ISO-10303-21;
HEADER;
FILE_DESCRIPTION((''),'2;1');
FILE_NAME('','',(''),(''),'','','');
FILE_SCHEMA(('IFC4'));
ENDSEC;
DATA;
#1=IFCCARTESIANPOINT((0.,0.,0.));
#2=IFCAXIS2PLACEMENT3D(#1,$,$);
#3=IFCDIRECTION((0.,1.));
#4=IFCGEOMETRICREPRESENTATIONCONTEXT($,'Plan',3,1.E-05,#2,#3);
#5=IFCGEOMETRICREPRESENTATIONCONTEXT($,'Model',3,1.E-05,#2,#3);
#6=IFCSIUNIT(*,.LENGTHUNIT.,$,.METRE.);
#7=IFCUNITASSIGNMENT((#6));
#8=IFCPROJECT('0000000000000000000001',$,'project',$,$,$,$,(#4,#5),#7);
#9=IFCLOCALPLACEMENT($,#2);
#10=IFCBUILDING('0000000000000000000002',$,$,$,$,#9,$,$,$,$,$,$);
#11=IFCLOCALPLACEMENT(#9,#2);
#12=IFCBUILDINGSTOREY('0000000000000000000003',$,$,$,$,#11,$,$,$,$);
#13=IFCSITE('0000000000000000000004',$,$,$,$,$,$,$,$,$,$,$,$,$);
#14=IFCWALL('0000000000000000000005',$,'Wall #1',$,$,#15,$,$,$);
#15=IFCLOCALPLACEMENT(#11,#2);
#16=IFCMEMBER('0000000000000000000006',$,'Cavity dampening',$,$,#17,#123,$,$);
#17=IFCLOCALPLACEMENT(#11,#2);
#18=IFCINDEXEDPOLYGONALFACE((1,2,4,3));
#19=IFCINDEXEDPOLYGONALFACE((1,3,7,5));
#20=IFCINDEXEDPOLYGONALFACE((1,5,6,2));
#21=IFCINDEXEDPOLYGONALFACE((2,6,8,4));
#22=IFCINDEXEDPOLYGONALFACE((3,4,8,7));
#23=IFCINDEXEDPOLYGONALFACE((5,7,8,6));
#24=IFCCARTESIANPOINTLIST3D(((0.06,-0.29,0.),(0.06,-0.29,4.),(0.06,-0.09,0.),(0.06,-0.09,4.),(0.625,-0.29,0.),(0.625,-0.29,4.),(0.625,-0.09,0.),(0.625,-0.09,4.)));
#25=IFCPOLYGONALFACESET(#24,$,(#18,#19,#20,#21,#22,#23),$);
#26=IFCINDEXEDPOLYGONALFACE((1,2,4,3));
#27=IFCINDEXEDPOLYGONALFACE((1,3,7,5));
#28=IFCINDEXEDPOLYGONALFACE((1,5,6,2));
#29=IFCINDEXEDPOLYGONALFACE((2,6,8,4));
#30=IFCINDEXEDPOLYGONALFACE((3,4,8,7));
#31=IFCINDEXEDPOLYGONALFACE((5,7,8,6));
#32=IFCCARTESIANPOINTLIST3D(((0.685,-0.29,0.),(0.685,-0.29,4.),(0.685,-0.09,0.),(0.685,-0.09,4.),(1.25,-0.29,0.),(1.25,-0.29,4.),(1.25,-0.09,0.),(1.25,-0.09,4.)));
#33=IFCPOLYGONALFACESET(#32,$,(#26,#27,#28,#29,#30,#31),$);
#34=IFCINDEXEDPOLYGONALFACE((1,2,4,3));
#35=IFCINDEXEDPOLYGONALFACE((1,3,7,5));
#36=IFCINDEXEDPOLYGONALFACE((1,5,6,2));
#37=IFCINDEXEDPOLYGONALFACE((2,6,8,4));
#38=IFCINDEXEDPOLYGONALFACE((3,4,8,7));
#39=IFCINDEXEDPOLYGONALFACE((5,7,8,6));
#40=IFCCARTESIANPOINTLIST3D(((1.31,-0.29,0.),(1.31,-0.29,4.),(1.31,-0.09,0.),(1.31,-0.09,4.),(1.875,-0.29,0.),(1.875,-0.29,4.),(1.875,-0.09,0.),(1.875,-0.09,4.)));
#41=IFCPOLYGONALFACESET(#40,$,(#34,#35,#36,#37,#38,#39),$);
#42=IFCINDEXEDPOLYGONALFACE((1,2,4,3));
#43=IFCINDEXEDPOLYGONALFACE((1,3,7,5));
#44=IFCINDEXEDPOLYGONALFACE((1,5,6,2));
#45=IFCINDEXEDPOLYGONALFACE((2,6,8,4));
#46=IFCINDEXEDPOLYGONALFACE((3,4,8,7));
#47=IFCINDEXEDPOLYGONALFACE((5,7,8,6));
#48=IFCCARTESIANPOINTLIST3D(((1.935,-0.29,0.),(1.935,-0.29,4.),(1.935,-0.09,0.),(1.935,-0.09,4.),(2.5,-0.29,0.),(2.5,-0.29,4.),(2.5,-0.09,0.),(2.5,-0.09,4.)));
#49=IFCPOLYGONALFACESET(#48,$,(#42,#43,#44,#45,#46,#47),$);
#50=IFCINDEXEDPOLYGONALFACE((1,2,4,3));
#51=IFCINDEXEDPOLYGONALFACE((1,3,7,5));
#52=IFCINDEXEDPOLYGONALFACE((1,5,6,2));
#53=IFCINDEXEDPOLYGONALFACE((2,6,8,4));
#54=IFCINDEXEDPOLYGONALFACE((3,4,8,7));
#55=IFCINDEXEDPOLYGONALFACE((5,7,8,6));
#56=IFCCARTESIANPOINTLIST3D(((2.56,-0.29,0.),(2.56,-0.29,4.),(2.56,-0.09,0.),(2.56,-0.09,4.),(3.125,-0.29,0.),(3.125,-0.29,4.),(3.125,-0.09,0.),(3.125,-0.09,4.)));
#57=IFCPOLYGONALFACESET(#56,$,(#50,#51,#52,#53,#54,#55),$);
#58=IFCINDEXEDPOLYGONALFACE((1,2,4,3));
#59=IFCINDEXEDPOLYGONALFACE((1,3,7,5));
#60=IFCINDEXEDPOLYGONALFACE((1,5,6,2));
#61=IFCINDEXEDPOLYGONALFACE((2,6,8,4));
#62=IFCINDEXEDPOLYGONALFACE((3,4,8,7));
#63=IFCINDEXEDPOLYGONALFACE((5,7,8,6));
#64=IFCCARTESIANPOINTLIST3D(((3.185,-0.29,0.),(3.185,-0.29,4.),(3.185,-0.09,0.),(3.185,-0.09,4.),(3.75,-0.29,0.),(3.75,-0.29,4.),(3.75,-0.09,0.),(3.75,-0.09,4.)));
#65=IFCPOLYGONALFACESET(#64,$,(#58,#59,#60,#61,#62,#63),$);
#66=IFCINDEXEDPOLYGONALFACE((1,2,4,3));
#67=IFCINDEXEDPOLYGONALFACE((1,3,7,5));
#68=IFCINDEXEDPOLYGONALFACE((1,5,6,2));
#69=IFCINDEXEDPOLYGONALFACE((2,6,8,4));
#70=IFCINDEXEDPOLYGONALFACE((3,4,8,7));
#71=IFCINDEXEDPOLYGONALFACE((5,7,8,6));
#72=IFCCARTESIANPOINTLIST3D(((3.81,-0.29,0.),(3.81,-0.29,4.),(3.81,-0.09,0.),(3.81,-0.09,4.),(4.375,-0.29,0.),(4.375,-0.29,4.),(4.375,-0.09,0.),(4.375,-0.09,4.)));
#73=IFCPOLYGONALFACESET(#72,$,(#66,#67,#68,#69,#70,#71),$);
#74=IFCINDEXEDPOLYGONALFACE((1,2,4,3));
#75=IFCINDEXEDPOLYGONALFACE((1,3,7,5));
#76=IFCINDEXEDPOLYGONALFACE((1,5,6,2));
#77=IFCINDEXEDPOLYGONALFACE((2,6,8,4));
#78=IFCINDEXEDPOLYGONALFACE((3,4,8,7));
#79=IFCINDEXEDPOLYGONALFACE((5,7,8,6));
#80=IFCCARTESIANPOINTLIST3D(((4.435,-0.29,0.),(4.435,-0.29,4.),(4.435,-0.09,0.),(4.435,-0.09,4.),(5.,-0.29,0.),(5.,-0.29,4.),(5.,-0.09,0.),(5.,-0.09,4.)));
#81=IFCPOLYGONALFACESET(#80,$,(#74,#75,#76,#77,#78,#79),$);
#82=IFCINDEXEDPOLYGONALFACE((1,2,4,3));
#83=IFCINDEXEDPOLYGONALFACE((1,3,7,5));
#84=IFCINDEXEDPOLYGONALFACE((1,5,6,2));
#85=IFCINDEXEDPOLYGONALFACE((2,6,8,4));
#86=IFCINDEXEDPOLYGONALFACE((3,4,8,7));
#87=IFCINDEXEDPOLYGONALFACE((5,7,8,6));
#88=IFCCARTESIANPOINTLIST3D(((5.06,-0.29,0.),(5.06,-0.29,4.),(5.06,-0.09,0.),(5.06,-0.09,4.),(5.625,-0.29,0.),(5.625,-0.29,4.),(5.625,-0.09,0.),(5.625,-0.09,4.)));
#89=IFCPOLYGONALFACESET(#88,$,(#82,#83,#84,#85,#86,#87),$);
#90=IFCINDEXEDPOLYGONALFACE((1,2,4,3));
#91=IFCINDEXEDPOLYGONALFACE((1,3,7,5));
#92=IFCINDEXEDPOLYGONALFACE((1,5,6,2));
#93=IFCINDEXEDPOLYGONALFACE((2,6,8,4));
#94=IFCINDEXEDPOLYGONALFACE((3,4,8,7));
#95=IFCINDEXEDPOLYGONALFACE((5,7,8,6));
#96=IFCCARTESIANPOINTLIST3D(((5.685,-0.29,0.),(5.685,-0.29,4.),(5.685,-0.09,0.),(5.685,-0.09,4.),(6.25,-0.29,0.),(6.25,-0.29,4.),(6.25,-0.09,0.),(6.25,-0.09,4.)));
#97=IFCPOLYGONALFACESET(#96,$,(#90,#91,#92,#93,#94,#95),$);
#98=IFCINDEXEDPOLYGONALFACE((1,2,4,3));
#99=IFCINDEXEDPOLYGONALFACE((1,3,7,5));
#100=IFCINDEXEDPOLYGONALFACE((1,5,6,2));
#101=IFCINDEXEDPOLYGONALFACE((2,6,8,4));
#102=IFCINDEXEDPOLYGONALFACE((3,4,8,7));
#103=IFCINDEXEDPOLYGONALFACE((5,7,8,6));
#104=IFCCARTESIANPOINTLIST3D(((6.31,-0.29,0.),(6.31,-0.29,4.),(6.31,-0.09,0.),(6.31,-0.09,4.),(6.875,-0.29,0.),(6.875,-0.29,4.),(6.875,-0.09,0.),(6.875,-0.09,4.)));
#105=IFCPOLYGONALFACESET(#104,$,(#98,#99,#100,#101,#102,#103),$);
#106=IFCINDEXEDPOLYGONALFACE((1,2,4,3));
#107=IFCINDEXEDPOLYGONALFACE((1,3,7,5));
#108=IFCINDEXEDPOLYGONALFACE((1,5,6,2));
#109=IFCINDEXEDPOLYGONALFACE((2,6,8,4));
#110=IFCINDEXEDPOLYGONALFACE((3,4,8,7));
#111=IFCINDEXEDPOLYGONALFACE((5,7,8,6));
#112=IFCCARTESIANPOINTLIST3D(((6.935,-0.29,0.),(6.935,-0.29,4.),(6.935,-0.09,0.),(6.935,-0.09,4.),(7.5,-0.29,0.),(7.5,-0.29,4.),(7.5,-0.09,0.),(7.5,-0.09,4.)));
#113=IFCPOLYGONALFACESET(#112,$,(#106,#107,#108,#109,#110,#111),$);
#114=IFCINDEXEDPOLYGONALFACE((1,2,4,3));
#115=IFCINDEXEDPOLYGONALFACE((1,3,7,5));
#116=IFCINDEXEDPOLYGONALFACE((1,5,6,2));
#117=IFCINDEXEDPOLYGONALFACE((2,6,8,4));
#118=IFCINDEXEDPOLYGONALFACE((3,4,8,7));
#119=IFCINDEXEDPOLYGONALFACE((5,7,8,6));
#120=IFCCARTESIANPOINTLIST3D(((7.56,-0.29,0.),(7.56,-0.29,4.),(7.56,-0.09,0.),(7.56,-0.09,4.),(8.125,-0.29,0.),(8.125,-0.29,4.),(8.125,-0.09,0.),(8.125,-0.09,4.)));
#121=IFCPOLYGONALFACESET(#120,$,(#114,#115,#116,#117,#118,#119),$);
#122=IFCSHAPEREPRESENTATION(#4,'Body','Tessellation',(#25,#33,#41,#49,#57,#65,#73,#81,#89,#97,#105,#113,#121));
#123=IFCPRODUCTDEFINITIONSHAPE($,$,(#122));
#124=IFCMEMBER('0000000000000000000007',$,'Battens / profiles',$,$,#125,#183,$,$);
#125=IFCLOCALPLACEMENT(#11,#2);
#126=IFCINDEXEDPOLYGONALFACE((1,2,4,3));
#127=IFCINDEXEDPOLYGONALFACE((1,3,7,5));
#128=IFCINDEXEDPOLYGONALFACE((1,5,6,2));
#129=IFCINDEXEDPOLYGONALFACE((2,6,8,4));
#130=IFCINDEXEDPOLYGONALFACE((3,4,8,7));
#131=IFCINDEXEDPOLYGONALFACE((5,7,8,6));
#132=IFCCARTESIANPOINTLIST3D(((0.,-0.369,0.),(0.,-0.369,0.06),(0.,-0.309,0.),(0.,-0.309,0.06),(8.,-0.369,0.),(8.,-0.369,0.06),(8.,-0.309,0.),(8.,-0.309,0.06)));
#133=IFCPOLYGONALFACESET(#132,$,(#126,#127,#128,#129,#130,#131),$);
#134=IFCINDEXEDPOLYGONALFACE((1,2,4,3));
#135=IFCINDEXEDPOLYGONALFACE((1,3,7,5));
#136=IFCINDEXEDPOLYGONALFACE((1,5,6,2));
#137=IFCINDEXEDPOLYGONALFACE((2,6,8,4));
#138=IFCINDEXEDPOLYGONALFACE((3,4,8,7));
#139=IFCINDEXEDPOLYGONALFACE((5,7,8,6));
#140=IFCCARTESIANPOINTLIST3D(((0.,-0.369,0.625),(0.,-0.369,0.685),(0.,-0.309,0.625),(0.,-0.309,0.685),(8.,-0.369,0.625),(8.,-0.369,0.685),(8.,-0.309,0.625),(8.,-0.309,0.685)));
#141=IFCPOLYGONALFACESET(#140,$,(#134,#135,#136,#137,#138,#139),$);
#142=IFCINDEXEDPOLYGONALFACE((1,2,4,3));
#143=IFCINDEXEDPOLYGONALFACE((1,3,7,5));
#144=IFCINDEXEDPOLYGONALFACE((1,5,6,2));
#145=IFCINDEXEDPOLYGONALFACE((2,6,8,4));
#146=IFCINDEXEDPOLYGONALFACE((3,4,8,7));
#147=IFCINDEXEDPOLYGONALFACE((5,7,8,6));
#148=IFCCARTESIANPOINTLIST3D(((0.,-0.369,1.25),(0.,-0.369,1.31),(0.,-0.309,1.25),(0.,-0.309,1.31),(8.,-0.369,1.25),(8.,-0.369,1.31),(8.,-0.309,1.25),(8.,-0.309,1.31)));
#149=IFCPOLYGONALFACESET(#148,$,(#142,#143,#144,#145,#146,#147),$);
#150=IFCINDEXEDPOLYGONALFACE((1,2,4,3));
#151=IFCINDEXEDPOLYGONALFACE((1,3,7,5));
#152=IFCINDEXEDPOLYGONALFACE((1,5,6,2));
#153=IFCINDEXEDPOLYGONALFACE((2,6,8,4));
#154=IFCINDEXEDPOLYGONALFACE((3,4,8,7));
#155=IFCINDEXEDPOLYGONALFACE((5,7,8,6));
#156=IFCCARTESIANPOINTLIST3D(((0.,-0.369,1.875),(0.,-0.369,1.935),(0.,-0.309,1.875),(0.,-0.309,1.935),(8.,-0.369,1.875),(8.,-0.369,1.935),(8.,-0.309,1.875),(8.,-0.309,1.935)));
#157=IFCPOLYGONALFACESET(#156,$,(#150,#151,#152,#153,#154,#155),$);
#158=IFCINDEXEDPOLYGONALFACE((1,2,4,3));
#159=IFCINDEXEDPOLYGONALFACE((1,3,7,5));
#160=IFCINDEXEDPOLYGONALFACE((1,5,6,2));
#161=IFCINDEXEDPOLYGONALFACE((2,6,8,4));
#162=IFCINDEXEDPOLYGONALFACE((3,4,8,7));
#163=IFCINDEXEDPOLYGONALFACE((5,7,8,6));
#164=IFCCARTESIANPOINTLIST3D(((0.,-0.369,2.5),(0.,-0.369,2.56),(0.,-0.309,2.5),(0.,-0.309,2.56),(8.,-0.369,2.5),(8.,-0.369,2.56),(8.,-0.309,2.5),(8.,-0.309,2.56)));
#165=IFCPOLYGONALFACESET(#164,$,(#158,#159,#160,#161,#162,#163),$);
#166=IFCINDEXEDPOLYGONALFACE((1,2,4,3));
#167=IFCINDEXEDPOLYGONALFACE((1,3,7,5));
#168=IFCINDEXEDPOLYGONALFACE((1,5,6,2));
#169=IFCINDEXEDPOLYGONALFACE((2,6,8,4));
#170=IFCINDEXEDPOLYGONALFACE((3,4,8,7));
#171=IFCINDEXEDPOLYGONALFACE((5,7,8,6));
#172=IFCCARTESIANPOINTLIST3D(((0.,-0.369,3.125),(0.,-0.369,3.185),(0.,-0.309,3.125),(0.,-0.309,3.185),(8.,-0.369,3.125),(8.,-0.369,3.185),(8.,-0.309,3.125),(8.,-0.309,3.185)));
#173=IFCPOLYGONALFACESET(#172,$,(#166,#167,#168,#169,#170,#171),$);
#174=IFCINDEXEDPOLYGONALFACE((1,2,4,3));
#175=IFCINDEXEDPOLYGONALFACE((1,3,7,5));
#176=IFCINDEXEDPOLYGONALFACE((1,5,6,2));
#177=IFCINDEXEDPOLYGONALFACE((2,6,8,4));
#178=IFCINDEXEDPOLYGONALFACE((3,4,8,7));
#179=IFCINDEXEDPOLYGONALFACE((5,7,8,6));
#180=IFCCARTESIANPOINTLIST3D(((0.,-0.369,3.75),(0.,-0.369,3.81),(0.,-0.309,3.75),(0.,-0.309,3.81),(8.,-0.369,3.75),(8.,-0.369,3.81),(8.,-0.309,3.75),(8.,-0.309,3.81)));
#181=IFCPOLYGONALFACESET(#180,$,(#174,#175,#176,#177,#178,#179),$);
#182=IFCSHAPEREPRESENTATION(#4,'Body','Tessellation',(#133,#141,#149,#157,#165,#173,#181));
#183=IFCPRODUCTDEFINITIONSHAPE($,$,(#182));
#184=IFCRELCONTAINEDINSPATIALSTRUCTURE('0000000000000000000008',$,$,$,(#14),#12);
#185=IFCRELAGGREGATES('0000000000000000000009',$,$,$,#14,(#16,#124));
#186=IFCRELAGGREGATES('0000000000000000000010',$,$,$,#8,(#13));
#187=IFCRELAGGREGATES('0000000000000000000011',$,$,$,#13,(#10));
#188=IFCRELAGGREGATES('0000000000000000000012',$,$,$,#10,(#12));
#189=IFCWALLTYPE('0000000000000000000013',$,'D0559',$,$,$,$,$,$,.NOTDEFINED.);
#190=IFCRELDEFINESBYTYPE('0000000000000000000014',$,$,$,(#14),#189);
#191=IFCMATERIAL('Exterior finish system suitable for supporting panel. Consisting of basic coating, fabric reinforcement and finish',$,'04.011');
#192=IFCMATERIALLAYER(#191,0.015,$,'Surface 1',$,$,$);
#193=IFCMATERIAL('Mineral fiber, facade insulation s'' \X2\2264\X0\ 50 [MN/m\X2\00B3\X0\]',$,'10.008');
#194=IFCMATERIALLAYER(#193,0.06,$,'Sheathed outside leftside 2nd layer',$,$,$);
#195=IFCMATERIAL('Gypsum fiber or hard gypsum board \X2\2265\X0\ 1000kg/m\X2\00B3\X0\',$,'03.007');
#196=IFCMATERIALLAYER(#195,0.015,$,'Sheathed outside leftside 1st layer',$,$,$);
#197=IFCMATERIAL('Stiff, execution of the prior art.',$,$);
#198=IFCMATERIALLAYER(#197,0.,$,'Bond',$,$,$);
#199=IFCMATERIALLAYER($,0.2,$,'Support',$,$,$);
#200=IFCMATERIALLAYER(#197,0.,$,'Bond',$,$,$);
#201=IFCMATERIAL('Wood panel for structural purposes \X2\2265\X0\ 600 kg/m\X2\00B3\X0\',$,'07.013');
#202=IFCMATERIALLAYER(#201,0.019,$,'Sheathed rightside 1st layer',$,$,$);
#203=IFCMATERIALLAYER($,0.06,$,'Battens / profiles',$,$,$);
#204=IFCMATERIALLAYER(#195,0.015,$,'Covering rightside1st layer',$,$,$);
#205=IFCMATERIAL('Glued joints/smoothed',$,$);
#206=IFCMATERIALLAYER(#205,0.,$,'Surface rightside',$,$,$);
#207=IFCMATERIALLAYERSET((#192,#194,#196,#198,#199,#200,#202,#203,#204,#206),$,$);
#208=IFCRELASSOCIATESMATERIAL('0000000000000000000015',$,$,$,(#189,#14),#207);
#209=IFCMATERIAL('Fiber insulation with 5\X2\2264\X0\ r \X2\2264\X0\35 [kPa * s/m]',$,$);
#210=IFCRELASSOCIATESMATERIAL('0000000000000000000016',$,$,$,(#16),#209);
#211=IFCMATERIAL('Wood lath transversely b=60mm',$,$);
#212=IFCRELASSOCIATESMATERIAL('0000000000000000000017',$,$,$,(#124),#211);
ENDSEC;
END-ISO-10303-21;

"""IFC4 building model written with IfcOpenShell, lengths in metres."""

from ifc_helpers import new_model, si_unit, direction, frame, frame_2d, origin, place, context, project, spatial, rectangle, extrude, material, layer, layer_set, type_object, element, aggregate, save


model = new_model("IFC4")

# Units and contexts
plan_context = context("Plan", 3, precision=1e-05, world=origin(), true_north=direction((0.0, 1.0)))
model_context = context("Model", 3, precision=1e-05, world=origin(), true_north=direction((0.0, 1.0)))
ifc_project = project(units=[si_unit("LENGTHUNIT", "METRE")], contexts=[plan_context, model_context])

# Site, building, storey
site = spatial("IfcSite", under=ifc_project)
building_placement = place(None, origin())
building = spatial("IfcBuilding", under=site, at=building_placement)
storey_placement = place(building_placement, origin())
storey = spatial("IfcBuildingStorey", under=building, at=storey_placement)

# Wall, members
ifc_material_1 = material(Name="Exterior finish system suitable for supporting panel. Consisting of basic coating, fabric reinforcement and finish", Category="04.011")
ifc_layer_1 = layer(ifc_material_1, 0.015, Name="Surface 1")
ifc_material_2 = material(Name="Mineral fiber, facade insulation s' ≤ 50 [MN/m³]", Category="10.008")
ifc_layer_2 = layer(ifc_material_2, 0.06, Name="Sheathed outside leftside 2nd layer")
ifc_material_3 = material(Name="Gypsum fiber or hard gypsum board ≥ 1000kg/m³", Category="03.007")
ifc_layer_3 = layer(ifc_material_3, 0.015, Name="Sheathed outside leftside 1st layer")
ifc_material_4 = material(Name="Stiff, execution of the prior art.")
ifc_layer_4 = layer(ifc_material_4, 0.0, Name="Bond")
ifc_layer_5 = layer(None, 0.2, Name="Support")
ifc_layer_6 = layer(ifc_material_4, 0.0, Name="Bond")
ifc_material_5 = material(Name="Wood panel for structural purposes ≥ 600 kg/m³", Category="07.013")
ifc_layer_7 = layer(ifc_material_5, 0.019, Name="Sheathed rightside 1st layer")
ifc_layer_8 = layer(None, 0.06, Name="Battens / profiles")
ifc_layer_9 = layer(ifc_material_3, 0.015, Name="Covering rightside1st layer")
ifc_material_6 = material(Name="Glued joints/smoothed")
ifc_layer_10 = layer(ifc_material_6, 0.0, Name="Surface rightside")
ifc_layer_set = layer_set([ifc_layer_1, ifc_layer_2, ifc_layer_3, ifc_layer_4, ifc_layer_5, ifc_layer_6, ifc_layer_7, ifc_layer_8, ifc_layer_9, ifc_layer_10])
wall_type = type_object("IfcWallType", Name="D0559", PredefinedType="NOTDEFINED", material=ifc_layer_set)
wall_placement = place(None, frame((0.0, 0.0, 0.0), z_axis=(0.0, -1.0, 0.0), x_axis=(1.0, 0.0, 0.0)))
wall = element("IfcWall", 1, at=wall_placement, inside=storey, type_object=wall_type, material=ifc_layer_set, Name="Wall #1")
ifc_material_7 = material(Name="Fiber insulation with 5≤ r ≤35 [kPa * s/m]")
member_1_placement = place(wall_placement, origin())
member_1 = element("IfcMember", 2, at=member_1_placement, material=ifc_material_7, Name="Cavity dampening", context=plan_context, shape_type="SweptSolid", body=[
    extrude(rectangle(XDim=0.565, YDim=0.2, at=frame_2d((0.2825, 0.1), x_axis=(1.0, 0.0))), frame((0.06, 4.0, 0.09), z_axis=(0.0, -1.0, 0.0), x_axis=(1.0, 0.0, 0.0)), (0.0, 0.0, 1.0), 4.0),
    extrude(rectangle(XDim=0.565, YDim=0.2, at=frame_2d((0.2825, 0.1), x_axis=(1.0, 0.0))), frame((0.685, 4.0, 0.09), z_axis=(0.0, -1.0, 0.0), x_axis=(1.0, 0.0, 0.0)), (0.0, 0.0, 1.0), 4.0),
    extrude(rectangle(XDim=0.565, YDim=0.2, at=frame_2d((0.2825, 0.1), x_axis=(1.0, 0.0))), frame((1.31, 4.0, 0.09), z_axis=(0.0, -1.0, 0.0), x_axis=(1.0, 0.0, 0.0)), (0.0, 0.0, 1.0), 4.0),
    extrude(rectangle(XDim=0.565, YDim=0.2, at=frame_2d((0.2825, 0.1), x_axis=(1.0, 0.0))), frame((1.935, 4.0, 0.09), z_axis=(0.0, -1.0, 0.0), x_axis=(1.0, 0.0, 0.0)), (0.0, 0.0, 1.0), 4.0),
    extrude(rectangle(XDim=0.565, YDim=0.2, at=frame_2d((0.2825, 0.1), x_axis=(1.0, 0.0))), frame((2.56, 4.0, 0.09), z_axis=(0.0, -1.0, 0.0), x_axis=(1.0, 0.0, 0.0)), (0.0, 0.0, 1.0), 4.0),
    extrude(rectangle(XDim=0.565, YDim=0.2, at=frame_2d((0.2825, 0.1), x_axis=(1.0, 0.0))), frame((3.185, 4.0, 0.09), z_axis=(0.0, -1.0, 0.0), x_axis=(1.0, 0.0, 0.0)), (0.0, 0.0, 1.0), 4.0),
    extrude(rectangle(XDim=0.565, YDim=0.2, at=frame_2d((0.2825, 0.1), x_axis=(1.0, 0.0))), frame((3.81, 4.0, 0.09), z_axis=(0.0, -1.0, 0.0), x_axis=(1.0, 0.0, 0.0)), (0.0, 0.0, 1.0), 4.0),
    extrude(rectangle(XDim=0.565, YDim=0.2, at=frame_2d((0.2825, 0.1), x_axis=(1.0, 0.0))), frame((4.435, 4.0, 0.09), z_axis=(0.0, -1.0, 0.0), x_axis=(1.0, 0.0, 0.0)), (0.0, 0.0, 1.0), 4.0),
    extrude(rectangle(XDim=0.565, YDim=0.2, at=frame_2d((0.2825, 0.1), x_axis=(1.0, 0.0))), frame((5.06, 4.0, 0.09), z_axis=(0.0, -1.0, 0.0), x_axis=(1.0, 0.0, 0.0)), (0.0, 0.0, 1.0), 4.0),
    extrude(rectangle(XDim=0.565, YDim=0.2, at=frame_2d((0.2825, 0.1), x_axis=(1.0, 0.0))), frame((5.685, 4.0, 0.09), z_axis=(0.0, -1.0, 0.0), x_axis=(1.0, 0.0, 0.0)), (0.0, 0.0, 1.0), 4.0),
    extrude(rectangle(XDim=0.565, YDim=0.2, at=frame_2d((0.2825, 0.1), x_axis=(1.0, 0.0))), frame((6.31, 4.0, 0.09), z_axis=(0.0, -1.0, 0.0), x_axis=(1.0, 0.0, 0.0)), (0.0, 0.0, 1.0), 4.0),
    extrude(rectangle(XDim=0.565, YDim=0.2, at=frame_2d((0.2825, 0.1), x_axis=(1.0, 0.0))), frame((6.935, 4.0, 0.09), z_axis=(0.0, -1.0, 0.0), x_axis=(1.0, 0.0, 0.0)), (0.0, 0.0, 1.0), 4.0),
    extrude(rectangle(XDim=0.565, YDim=0.2, at=frame_2d((0.2825, 0.1), x_axis=(1.0, 0.0))), frame((7.56, 4.0, 0.09), z_axis=(0.0, -1.0, 0.0), x_axis=(1.0, 0.0, 0.0)), (0.0, 0.0, 1.0), 4.0),
])
ifc_material_8 = material(Name="Wood lath transversely b=60mm")
member_2_placement = place(wall_placement, origin())
member_2 = element("IfcMember", 3, at=member_2_placement, material=ifc_material_8, Name="Battens / profiles", context=plan_context, shape_type="SweptSolid", body=[
    extrude(rectangle(XDim=0.06, YDim=0.06, at=frame_2d((0.03, 0.03), x_axis=(1.0, 0.0))), frame((0.0, 0.0, 0.309), z_axis=(1.0, 0.0, 0.0), x_axis=(0.0, 1.0, 0.0)), (0.0, 0.0, 1.0), 8.0),
    extrude(rectangle(XDim=0.06, YDim=0.06, at=frame_2d((0.03, 0.03), x_axis=(1.0, 0.0))), frame((0.0, 0.625, 0.309), z_axis=(1.0, 0.0, 0.0), x_axis=(0.0, 1.0, 0.0)), (0.0, 0.0, 1.0), 8.0),
    extrude(rectangle(XDim=0.06, YDim=0.06, at=frame_2d((0.03, 0.03), x_axis=(1.0, 0.0))), frame((0.0, 1.25, 0.309), z_axis=(1.0, 0.0, 0.0), x_axis=(0.0, 1.0, 0.0)), (0.0, 0.0, 1.0), 8.0),
    extrude(rectangle(XDim=0.06, YDim=0.06, at=frame_2d((0.03, 0.03), x_axis=(1.0, 0.0))), frame((0.0, 1.875, 0.309), z_axis=(1.0, 0.0, 0.0), x_axis=(0.0, 1.0, 0.0)), (0.0, 0.0, 1.0), 8.0),
    extrude(rectangle(XDim=0.06, YDim=0.06, at=frame_2d((0.03, 0.03), x_axis=(1.0, 0.0))), frame((0.0, 2.5, 0.309), z_axis=(1.0, 0.0, 0.0), x_axis=(0.0, 1.0, 0.0)), (0.0, 0.0, 1.0), 8.0),
    extrude(rectangle(XDim=0.06, YDim=0.06, at=frame_2d((0.03, 0.03), x_axis=(1.0, 0.0))), frame((0.0, 3.125, 0.309), z_axis=(1.0, 0.0, 0.0), x_axis=(0.0, 1.0, 0.0)), (0.0, 0.0, 1.0), 8.0),
    extrude(rectangle(XDim=0.06, YDim=0.06, at=frame_2d((0.03, 0.03), x_axis=(1.0, 0.0))), frame((0.0, 3.75, 0.309), z_axis=(1.0, 0.0, 0.0), x_axis=(0.0, 1.0, 0.0)), (0.0, 0.0, 1.0), 8.0),
])
aggregate(wall, [member_1, member_2])

save(model, "model.ifc")
